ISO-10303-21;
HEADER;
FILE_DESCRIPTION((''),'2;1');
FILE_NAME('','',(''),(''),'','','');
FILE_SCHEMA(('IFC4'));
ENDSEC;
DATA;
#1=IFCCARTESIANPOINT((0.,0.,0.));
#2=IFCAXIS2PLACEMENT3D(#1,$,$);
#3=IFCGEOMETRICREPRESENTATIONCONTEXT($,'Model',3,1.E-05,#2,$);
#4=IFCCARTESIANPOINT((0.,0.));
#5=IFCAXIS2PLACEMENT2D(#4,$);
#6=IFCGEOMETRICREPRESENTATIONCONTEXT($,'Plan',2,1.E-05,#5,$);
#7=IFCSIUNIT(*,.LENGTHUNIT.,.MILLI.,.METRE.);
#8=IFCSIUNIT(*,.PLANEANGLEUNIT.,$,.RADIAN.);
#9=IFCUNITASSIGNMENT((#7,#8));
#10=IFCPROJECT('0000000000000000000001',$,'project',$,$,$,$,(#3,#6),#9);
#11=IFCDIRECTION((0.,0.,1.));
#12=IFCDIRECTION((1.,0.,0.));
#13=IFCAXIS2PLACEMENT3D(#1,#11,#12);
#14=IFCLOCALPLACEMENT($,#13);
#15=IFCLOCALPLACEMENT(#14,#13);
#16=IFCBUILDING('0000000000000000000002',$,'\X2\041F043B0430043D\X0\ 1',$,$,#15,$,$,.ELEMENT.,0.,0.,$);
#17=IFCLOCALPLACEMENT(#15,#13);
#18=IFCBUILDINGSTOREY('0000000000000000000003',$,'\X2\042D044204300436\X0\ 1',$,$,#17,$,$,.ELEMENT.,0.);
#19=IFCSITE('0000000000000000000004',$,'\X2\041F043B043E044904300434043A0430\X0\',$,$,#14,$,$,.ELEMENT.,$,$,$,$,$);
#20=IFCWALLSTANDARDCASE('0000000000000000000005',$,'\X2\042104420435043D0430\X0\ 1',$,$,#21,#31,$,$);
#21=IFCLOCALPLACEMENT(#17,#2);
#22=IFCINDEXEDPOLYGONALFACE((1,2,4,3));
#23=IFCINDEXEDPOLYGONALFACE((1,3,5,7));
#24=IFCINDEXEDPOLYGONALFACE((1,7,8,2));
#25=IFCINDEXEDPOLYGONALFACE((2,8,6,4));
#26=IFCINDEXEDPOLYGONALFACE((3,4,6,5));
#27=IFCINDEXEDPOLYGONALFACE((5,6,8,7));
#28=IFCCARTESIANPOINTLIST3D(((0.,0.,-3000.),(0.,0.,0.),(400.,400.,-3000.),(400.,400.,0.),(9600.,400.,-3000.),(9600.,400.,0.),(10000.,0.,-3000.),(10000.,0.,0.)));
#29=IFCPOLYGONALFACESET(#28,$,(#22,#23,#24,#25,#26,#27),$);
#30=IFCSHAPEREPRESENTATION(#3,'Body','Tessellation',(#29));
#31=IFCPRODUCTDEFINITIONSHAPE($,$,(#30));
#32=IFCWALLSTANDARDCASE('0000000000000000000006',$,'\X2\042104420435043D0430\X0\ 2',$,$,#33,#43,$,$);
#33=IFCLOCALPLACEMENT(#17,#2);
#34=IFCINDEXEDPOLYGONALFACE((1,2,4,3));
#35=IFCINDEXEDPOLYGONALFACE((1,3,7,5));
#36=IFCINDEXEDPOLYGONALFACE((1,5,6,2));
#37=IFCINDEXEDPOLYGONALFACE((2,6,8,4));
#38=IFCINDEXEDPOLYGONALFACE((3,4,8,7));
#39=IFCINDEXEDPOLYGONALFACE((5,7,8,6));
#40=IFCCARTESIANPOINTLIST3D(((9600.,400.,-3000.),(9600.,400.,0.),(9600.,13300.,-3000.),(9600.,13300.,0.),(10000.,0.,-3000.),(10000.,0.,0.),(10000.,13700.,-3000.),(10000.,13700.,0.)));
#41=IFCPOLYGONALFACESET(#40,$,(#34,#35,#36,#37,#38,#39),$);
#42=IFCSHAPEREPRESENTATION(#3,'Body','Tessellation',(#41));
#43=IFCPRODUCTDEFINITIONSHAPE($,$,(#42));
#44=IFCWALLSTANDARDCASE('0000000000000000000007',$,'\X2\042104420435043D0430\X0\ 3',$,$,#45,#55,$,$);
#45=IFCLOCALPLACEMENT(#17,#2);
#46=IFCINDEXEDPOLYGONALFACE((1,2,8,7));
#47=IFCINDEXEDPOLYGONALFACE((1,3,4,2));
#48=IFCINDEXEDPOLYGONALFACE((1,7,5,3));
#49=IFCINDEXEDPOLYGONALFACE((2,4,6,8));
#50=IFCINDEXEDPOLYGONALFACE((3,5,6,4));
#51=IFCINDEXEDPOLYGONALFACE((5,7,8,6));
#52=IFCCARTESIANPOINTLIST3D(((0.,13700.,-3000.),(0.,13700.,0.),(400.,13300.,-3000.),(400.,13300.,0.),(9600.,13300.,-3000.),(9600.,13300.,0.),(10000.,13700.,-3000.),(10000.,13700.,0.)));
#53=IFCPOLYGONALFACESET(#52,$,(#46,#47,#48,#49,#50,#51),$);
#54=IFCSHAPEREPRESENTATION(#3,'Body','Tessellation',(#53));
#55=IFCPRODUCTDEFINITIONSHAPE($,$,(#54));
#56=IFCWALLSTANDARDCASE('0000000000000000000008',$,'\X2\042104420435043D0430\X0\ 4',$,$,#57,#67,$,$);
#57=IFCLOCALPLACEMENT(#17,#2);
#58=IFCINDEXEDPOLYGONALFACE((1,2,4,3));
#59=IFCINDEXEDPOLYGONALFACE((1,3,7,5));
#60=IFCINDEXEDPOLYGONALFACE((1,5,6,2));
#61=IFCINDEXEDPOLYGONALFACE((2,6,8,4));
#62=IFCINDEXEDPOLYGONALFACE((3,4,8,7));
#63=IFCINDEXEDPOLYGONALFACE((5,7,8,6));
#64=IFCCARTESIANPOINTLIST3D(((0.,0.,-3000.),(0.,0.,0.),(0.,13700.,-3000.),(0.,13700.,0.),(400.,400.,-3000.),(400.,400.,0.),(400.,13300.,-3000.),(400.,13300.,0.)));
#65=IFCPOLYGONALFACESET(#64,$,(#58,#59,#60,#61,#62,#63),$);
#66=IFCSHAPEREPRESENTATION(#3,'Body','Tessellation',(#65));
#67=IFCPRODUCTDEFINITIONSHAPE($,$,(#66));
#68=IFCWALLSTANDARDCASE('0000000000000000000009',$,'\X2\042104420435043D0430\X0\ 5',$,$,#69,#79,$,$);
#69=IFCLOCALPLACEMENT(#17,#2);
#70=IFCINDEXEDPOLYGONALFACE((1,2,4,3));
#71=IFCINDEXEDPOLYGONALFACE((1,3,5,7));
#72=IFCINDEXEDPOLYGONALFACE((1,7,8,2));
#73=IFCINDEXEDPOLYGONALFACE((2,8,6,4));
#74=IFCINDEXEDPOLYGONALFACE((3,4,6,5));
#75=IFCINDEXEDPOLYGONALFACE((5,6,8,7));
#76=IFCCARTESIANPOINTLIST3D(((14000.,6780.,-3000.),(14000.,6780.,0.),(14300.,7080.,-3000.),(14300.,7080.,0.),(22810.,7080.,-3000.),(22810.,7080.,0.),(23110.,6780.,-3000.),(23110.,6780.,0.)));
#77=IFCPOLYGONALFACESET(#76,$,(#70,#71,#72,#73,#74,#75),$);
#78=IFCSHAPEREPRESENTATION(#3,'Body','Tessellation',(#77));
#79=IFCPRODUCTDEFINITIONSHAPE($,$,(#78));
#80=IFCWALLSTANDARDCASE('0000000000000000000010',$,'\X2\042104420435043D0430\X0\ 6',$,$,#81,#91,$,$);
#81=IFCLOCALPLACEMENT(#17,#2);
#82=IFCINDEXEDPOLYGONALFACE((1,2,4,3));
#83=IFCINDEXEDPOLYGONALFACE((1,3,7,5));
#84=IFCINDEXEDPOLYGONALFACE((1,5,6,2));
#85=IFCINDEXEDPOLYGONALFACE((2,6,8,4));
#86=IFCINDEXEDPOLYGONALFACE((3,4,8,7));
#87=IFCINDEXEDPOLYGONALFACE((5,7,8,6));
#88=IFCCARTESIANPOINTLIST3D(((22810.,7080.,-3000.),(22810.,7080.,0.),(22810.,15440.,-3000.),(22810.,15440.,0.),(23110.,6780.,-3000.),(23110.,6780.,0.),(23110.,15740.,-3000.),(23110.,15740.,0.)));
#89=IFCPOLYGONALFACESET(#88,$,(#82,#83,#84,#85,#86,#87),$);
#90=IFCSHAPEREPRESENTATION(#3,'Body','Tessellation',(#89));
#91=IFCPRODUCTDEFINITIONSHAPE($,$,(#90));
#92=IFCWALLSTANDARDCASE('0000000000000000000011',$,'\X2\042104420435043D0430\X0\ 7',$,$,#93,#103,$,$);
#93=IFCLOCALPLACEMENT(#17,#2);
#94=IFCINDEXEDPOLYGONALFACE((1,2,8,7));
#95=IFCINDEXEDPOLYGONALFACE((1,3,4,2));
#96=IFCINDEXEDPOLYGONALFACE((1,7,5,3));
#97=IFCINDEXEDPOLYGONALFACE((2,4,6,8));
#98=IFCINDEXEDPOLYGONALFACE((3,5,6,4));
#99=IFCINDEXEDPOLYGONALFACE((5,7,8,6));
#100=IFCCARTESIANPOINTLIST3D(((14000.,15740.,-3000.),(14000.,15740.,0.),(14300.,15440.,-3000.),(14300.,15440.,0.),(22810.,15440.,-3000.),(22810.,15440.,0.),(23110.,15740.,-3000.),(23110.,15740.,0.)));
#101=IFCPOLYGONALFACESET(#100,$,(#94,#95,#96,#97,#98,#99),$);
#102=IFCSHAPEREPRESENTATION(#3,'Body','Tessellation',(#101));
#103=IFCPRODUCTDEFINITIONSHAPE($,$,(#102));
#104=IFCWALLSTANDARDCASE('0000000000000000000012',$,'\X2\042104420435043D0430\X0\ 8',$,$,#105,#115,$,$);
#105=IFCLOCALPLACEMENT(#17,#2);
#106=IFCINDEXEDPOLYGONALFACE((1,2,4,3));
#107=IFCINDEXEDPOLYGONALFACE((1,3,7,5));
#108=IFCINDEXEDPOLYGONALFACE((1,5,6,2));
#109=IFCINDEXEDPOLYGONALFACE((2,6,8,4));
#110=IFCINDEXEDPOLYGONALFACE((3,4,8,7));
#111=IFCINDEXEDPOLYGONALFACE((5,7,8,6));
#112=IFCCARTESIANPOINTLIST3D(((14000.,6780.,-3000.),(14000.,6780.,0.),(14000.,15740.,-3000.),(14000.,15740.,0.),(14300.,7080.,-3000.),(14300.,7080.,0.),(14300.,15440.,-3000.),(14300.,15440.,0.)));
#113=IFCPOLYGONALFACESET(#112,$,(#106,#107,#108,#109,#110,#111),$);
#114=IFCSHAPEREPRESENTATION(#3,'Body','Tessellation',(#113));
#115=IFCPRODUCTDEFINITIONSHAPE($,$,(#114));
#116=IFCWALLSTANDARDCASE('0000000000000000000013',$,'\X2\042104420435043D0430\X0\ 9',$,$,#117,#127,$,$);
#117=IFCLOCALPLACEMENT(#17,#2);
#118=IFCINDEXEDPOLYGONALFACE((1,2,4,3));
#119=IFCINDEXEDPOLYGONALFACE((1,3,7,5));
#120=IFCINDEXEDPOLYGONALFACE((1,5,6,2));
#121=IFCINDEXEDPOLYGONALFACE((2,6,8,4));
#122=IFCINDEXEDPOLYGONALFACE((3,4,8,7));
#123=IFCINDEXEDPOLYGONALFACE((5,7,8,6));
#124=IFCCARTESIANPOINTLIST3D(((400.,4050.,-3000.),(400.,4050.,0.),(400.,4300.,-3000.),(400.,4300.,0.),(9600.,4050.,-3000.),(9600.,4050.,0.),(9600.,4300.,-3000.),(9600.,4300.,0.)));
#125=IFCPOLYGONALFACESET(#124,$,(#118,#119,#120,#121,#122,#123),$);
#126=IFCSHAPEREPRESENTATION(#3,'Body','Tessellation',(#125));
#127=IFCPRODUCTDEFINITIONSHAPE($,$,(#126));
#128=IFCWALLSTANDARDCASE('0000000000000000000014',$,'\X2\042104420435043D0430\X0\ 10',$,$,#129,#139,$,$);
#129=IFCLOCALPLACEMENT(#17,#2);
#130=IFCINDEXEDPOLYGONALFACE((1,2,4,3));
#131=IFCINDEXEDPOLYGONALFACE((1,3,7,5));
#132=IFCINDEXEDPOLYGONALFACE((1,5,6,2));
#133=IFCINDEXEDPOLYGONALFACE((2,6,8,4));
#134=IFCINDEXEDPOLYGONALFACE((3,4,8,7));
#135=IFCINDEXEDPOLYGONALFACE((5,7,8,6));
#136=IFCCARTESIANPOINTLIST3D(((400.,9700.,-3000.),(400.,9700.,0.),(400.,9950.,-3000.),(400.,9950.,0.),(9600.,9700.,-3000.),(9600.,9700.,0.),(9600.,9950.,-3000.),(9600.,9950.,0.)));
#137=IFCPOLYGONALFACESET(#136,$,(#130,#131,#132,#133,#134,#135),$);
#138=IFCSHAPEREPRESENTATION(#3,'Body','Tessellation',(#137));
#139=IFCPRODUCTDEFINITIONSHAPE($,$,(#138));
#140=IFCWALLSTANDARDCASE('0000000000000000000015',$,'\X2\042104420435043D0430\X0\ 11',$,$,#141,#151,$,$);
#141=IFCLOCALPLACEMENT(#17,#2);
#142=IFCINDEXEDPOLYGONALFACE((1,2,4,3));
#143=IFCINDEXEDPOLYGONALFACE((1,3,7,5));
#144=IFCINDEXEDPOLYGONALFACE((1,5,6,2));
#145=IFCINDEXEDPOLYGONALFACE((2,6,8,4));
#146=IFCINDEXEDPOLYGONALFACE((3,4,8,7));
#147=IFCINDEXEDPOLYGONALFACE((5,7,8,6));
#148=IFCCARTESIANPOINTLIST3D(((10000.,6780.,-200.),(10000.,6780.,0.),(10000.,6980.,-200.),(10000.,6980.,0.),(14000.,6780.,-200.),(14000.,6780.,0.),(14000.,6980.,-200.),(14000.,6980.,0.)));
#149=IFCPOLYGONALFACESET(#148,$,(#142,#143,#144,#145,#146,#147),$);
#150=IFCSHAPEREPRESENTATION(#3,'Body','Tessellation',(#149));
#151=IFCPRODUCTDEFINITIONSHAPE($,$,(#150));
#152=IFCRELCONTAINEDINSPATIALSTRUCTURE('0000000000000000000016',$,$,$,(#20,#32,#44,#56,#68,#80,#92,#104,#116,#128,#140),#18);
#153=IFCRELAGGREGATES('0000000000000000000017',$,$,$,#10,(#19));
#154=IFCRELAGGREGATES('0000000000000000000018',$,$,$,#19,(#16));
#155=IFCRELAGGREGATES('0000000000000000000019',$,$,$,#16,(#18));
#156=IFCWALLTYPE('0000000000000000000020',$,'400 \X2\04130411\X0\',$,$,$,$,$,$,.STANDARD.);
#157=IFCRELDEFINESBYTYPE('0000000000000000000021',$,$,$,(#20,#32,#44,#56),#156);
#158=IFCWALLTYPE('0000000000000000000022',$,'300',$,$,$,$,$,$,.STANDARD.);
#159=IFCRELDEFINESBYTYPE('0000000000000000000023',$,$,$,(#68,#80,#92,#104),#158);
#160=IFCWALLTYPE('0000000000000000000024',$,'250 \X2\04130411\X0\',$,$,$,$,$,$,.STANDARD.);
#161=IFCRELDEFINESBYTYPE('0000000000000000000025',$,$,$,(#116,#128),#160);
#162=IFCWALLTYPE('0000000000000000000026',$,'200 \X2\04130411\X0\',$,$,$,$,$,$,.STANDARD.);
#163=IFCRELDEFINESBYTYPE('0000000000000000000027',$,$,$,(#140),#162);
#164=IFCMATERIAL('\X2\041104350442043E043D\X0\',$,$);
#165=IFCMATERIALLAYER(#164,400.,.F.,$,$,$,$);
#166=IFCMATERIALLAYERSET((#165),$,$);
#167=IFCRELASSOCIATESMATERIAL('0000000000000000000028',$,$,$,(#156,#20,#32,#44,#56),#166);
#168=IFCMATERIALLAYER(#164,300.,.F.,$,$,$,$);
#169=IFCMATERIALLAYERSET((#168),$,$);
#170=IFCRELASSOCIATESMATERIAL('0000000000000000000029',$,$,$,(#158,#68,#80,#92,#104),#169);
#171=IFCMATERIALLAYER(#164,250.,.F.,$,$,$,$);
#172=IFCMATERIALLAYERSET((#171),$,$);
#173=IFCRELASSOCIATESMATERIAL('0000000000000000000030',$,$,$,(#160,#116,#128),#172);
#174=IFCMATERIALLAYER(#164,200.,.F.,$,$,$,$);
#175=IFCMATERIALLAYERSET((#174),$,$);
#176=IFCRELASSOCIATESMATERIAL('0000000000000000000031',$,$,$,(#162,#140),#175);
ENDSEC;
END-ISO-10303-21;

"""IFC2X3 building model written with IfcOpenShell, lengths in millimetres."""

from ifc_helpers import new_model, si_unit, frame, origin, origin_with_axes, origin_2d, place, context, project, spatial, polyline, segment, composite_curve, outline, extrude, material, layer, layer_set, layer_usage, type_object, element, save


model = new_model("IFC2X3")

# Units and contexts
model_context = context("Model", 3, precision=1e-05, world=origin())
plan_context = context("Plan", 2, precision=1e-05, world=origin_2d())
ifc_project = project(units=[si_unit("LENGTHUNIT", "METRE", prefix="MILLI"), si_unit("PLANEANGLEUNIT", "RADIAN")], contexts=[model_context, plan_context])

# Site, building, storey
site_placement = place(None, origin_with_axes())
site = spatial("IfcSite", under=ifc_project, at=site_placement, Name="Площадка", CompositionType="ELEMENT")
building_placement = place(site_placement, origin_with_axes())
building = spatial("IfcBuilding", under=site, at=building_placement, Name="План 1", CompositionType="ELEMENT", ElevationOfRefHeight=0.0, ElevationOfTerrain=0.0)
storey_placement = place(building_placement, origin_with_axes())
storey = spatial("IfcBuildingStorey", under=building, at=storey_placement, Name="Этаж 1", CompositionType="ELEMENT", Elevation=0.0)

# Walls
ifc_material = material(Name="Бетон")
ifc_layer_1 = layer(ifc_material, 400.0, ventilated=False)
ifc_layer_set_1 = layer_set([ifc_layer_1])
ifc_layer_usage_1 = layer_usage(ifc_layer_set_1, "AXIS2", "POSITIVE", 0.0)
wall_type_1 = type_object("IfcWallType", Name="400 ГБ", PredefinedType="STANDARD", material=ifc_layer_set_1)
wall_1_placement = place(storey_placement, frame((0.0, 0.0, -3000.0), z_axis=(0.0, 0.0, 1.0), x_axis=(1.0, 0.0, 0.0)))
element("IfcWallStandardCase", 1, at=wall_1_placement, inside=storey, type_object=wall_type_1, material=ifc_layer_usage_1, Name="Стена 1", context=model_context, shape_type="SweptSolid", body=[
    extrude(outline(composite_curve([segment(polyline([(400.0, 400.0), (0.0, 0.0)]), True, "CONTINUOUS"), segment(polyline([(0.0, 0.0), (10000.0, 0.0)]), True, "CONTINUOUS"), segment(polyline([(10000.0, 0.0), (9600.0, 400.0)]), True, "CONTINUOUS"), segment(polyline([(9600.0, 400.0), (400.0, 400.0)]), True, "CONTINUOUS")], self_intersect=False)), origin_with_axes(), (0.0, 0.0, 1.0), 3000.0),
])
ifc_layer_usage_2 = layer_usage(ifc_layer_set_1, "AXIS2", "POSITIVE", 0.0)
wall_2_placement = place(storey_placement, frame((10000.0, 0.0, -3000.0), z_axis=(0.0, 0.0, 1.0), x_axis=(0.0, 1.0, 0.0)))
element("IfcWallStandardCase", 2, at=wall_2_placement, inside=storey, type_object=wall_type_1, material=ifc_layer_usage_2, Name="Стена 2", context=model_context, shape_type="SweptSolid", body=[
    extrude(outline(composite_curve([segment(polyline([(400.0, 400.0), (0.0, 0.0)]), True, "CONTINUOUS"), segment(polyline([(0.0, 0.0), (13700.0, 0.0)]), True, "CONTINUOUS"), segment(polyline([(13700.0, 0.0), (13300.0, 400.0)]), True, "CONTINUOUS"), segment(polyline([(13300.0, 400.0), (400.0, 400.0)]), True, "CONTINUOUS")], self_intersect=False)), origin_with_axes(), (0.0, 0.0, 1.0), 3000.0),
])
ifc_layer_usage_3 = layer_usage(ifc_layer_set_1, "AXIS2", "POSITIVE", 0.0)
wall_3_placement = place(storey_placement, frame((10000.0, 13700.0, -3000.0), z_axis=(0.0, 0.0, 1.0), x_axis=(-1.0, 0.0, 0.0)))
element("IfcWallStandardCase", 3, at=wall_3_placement, inside=storey, type_object=wall_type_1, material=ifc_layer_usage_3, Name="Стена 3", context=model_context, shape_type="SweptSolid", body=[
    extrude(outline(composite_curve([segment(polyline([(400.0, 400.0), (0.0, 0.0)]), True, "CONTINUOUS"), segment(polyline([(0.0, 0.0), (10000.0, 0.0)]), True, "CONTINUOUS"), segment(polyline([(10000.0, 0.0), (9600.0, 400.0)]), True, "CONTINUOUS"), segment(polyline([(9600.0, 400.0), (400.0, 400.0)]), True, "CONTINUOUS")], self_intersect=False)), origin_with_axes(), (0.0, 0.0, 1.0), 3000.0),
])
ifc_layer_usage_4 = layer_usage(ifc_layer_set_1, "AXIS2", "POSITIVE", 0.0)
wall_4_placement = place(storey_placement, frame((0.0, 13700.0, -3000.0), z_axis=(0.0, 0.0, 1.0), x_axis=(0.0, -1.0, 0.0)))
element("IfcWallStandardCase", 4, at=wall_4_placement, inside=storey, type_object=wall_type_1, material=ifc_layer_usage_4, Name="Стена 4", context=model_context, shape_type="SweptSolid", body=[
    extrude(outline(composite_curve([segment(polyline([(400.0, 400.0), (0.0, 0.0)]), True, "CONTINUOUS"), segment(polyline([(0.0, 0.0), (13700.0, 0.0)]), True, "CONTINUOUS"), segment(polyline([(13700.0, 0.0), (13300.0, 400.0)]), True, "CONTINUOUS"), segment(polyline([(13300.0, 400.0), (400.0, 400.0)]), True, "CONTINUOUS")], self_intersect=False)), origin_with_axes(), (0.0, 0.0, 1.0), 3000.0),
])
ifc_layer_2 = layer(ifc_material, 300.0, ventilated=False)
ifc_layer_set_2 = layer_set([ifc_layer_2])
ifc_layer_usage_5 = layer_usage(ifc_layer_set_2, "AXIS2", "POSITIVE", 0.0)
wall_type_2 = type_object("IfcWallType", Name="300", PredefinedType="STANDARD", material=ifc_layer_set_2)
wall_5_placement = place(storey_placement, frame((14000.0, 6780.0, -3000.0), z_axis=(0.0, 0.0, 1.0), x_axis=(1.0, 0.0, 0.0)))
element("IfcWallStandardCase", 5, at=wall_5_placement, inside=storey, type_object=wall_type_2, material=ifc_layer_usage_5, Name="Стена 5", context=model_context, shape_type="SweptSolid", body=[
    extrude(outline(composite_curve([segment(polyline([(300.0, 300.0), (0.0, 0.0)]), True, "CONTINUOUS"), segment(polyline([(0.0, 0.0), (9110.0, 0.0)]), True, "CONTINUOUS"), segment(polyline([(9110.0, 0.0), (8810.0, 300.0)]), True, "CONTINUOUS"), segment(polyline([(8810.0, 300.0), (300.0, 300.0)]), True, "CONTINUOUS")], self_intersect=False)), origin_with_axes(), (0.0, 0.0, 1.0), 3000.0),
])
ifc_layer_usage_6 = layer_usage(ifc_layer_set_2, "AXIS2", "POSITIVE", 0.0)
wall_6_placement = place(storey_placement, frame((23110.0, 6780.0, -3000.0), z_axis=(0.0, 0.0, 1.0), x_axis=(0.0, 1.0, 0.0)))
element("IfcWallStandardCase", 6, at=wall_6_placement, inside=storey, type_object=wall_type_2, material=ifc_layer_usage_6, Name="Стена 6", context=model_context, shape_type="SweptSolid", body=[
    extrude(outline(composite_curve([segment(polyline([(300.0, 300.0), (0.0, 0.0)]), True, "CONTINUOUS"), segment(polyline([(0.0, 0.0), (8960.0, 0.0)]), True, "CONTINUOUS"), segment(polyline([(8960.0, 0.0), (8660.0, 300.0)]), True, "CONTINUOUS"), segment(polyline([(8660.0, 300.0), (300.0, 300.0)]), True, "CONTINUOUS")], self_intersect=False)), origin_with_axes(), (0.0, 0.0, 1.0), 3000.0),
])
ifc_layer_usage_7 = layer_usage(ifc_layer_set_2, "AXIS2", "POSITIVE", 0.0)
wall_7_placement = place(storey_placement, frame((23110.0, 15740.0, -3000.0), z_axis=(0.0, 0.0, 1.0), x_axis=(-1.0, 0.0, 0.0)))
element("IfcWallStandardCase", 7, at=wall_7_placement, inside=storey, type_object=wall_type_2, material=ifc_layer_usage_7, Name="Стена 7", context=model_context, shape_type="SweptSolid", body=[
    extrude(outline(composite_curve([segment(polyline([(300.0, 300.0), (0.0, 0.0)]), True, "CONTINUOUS"), segment(polyline([(0.0, 0.0), (9110.0, 0.0)]), True, "CONTINUOUS"), segment(polyline([(9110.0, 0.0), (8810.0, 300.0)]), True, "CONTINUOUS"), segment(polyline([(8810.0, 300.0), (300.0, 300.0)]), True, "CONTINUOUS")], self_intersect=False)), origin_with_axes(), (0.0, 0.0, 1.0), 3000.0),
])
ifc_layer_usage_8 = layer_usage(ifc_layer_set_2, "AXIS2", "POSITIVE", 0.0)
wall_8_placement = place(storey_placement, frame((14000.0, 15740.0, -3000.0), z_axis=(0.0, 0.0, 1.0), x_axis=(0.0, -1.0, 0.0)))
element("IfcWallStandardCase", 8, at=wall_8_placement, inside=storey, type_object=wall_type_2, material=ifc_layer_usage_8, Name="Стена 8", context=model_context, shape_type="SweptSolid", body=[
    extrude(outline(composite_curve([segment(polyline([(300.0, 300.0), (0.0, 0.0)]), True, "CONTINUOUS"), segment(polyline([(0.0, 0.0), (8960.0, 0.0)]), True, "CONTINUOUS"), segment(polyline([(8960.0, 0.0), (8660.0, 300.0)]), True, "CONTINUOUS"), segment(polyline([(8660.0, 300.0), (300.0, 300.0)]), True, "CONTINUOUS")], self_intersect=False)), origin_with_axes(), (0.0, 0.0, 1.0), 3000.0),
])
ifc_layer_3 = layer(ifc_material, 250.0, ventilated=False)
ifc_layer_set_3 = layer_set([ifc_layer_3])
ifc_layer_usage_9 = layer_usage(ifc_layer_set_3, "AXIS2", "POSITIVE", -250.0)
wall_type_3 = type_object("IfcWallType", Name="250 ГБ", PredefinedType="STANDARD", material=ifc_layer_set_3)
wall_9_placement = place(storey_placement, frame((0.0, 4300.0, -3000.0), z_axis=(0.0, 0.0, 1.0), x_axis=(1.0, 0.0, 0.0)))
element("IfcWallStandardCase", 9, at=wall_9_placement, inside=storey, type_object=wall_type_3, material=ifc_layer_usage_9, Name="Стена 9", context=model_context, shape_type="SweptSolid", body=[
    extrude(outline(composite_curve([segment(polyline([(400.0, 0.0), (400.0, -250.0)]), True, "CONTINUOUS"), segment(polyline([(400.0, -250.0), (9600.0, -250.0)]), True, "CONTINUOUS"), segment(polyline([(9600.0, -250.0), (9600.0, 0.0)]), True, "CONTINUOUS"), segment(polyline([(9600.0, 0.0), (400.0, 0.0)]), True, "CONTINUOUS")], self_intersect=False)), origin_with_axes(), (0.0, 0.0, 1.0), 3000.0),
])
ifc_layer_usage_10 = layer_usage(ifc_layer_set_3, "AXIS2", "POSITIVE", -250.0)
wall_10_placement = place(storey_placement, frame((0.0, 9950.0, -3000.0), z_axis=(0.0, 0.0, 1.0), x_axis=(1.0, 0.0, 0.0)))
element("IfcWallStandardCase", 10, at=wall_10_placement, inside=storey, type_object=wall_type_3, material=ifc_layer_usage_10, Name="Стена 10", context=model_context, shape_type="SweptSolid", body=[
    extrude(outline(composite_curve([segment(polyline([(400.0, 0.0), (400.0, -250.0)]), True, "CONTINUOUS"), segment(polyline([(400.0, -250.0), (9600.0, -250.0)]), True, "CONTINUOUS"), segment(polyline([(9600.0, -250.0), (9600.0, 0.0)]), True, "CONTINUOUS"), segment(polyline([(9600.0, 0.0), (400.0, 0.0)]), True, "CONTINUOUS")], self_intersect=False)), origin_with_axes(), (0.0, 0.0, 1.0), 3000.0),
])
ifc_layer_4 = layer(ifc_material, 200.0, ventilated=False)
ifc_layer_set_4 = layer_set([ifc_layer_4])
ifc_layer_usage_11 = layer_usage(ifc_layer_set_4, "AXIS2", "POSITIVE", 0.0)
wall_type_4 = type_object("IfcWallType", Name="200 ГБ", PredefinedType="STANDARD", material=ifc_layer_set_4)
wall_11_placement = place(storey_placement, frame((10000.0, 6780.0, -200.0), z_axis=(0.0, 0.0, 1.0), x_axis=(1.0, 0.0, 0.0)))
element("IfcWallStandardCase", 11, at=wall_11_placement, inside=storey, type_object=wall_type_4, material=ifc_layer_usage_11, Name="Стена 11", context=model_context, shape_type="SweptSolid", body=[
    extrude(outline(composite_curve([segment(polyline([(0.0, 200.0), (0.0, 0.0)]), True, "CONTINUOUS"), segment(polyline([(0.0, 0.0), (4000.0, 0.0)]), True, "CONTINUOUS"), segment(polyline([(4000.0, 0.0), (4000.0, 200.0)]), True, "CONTINUOUS"), segment(polyline([(4000.0, 200.0), (0.0, 200.0)]), True, "CONTINUOUS")], self_intersect=False)), origin_with_axes(), (0.0, 0.0, 1.0), 200.0),
])

save(model, "model.ifc")
